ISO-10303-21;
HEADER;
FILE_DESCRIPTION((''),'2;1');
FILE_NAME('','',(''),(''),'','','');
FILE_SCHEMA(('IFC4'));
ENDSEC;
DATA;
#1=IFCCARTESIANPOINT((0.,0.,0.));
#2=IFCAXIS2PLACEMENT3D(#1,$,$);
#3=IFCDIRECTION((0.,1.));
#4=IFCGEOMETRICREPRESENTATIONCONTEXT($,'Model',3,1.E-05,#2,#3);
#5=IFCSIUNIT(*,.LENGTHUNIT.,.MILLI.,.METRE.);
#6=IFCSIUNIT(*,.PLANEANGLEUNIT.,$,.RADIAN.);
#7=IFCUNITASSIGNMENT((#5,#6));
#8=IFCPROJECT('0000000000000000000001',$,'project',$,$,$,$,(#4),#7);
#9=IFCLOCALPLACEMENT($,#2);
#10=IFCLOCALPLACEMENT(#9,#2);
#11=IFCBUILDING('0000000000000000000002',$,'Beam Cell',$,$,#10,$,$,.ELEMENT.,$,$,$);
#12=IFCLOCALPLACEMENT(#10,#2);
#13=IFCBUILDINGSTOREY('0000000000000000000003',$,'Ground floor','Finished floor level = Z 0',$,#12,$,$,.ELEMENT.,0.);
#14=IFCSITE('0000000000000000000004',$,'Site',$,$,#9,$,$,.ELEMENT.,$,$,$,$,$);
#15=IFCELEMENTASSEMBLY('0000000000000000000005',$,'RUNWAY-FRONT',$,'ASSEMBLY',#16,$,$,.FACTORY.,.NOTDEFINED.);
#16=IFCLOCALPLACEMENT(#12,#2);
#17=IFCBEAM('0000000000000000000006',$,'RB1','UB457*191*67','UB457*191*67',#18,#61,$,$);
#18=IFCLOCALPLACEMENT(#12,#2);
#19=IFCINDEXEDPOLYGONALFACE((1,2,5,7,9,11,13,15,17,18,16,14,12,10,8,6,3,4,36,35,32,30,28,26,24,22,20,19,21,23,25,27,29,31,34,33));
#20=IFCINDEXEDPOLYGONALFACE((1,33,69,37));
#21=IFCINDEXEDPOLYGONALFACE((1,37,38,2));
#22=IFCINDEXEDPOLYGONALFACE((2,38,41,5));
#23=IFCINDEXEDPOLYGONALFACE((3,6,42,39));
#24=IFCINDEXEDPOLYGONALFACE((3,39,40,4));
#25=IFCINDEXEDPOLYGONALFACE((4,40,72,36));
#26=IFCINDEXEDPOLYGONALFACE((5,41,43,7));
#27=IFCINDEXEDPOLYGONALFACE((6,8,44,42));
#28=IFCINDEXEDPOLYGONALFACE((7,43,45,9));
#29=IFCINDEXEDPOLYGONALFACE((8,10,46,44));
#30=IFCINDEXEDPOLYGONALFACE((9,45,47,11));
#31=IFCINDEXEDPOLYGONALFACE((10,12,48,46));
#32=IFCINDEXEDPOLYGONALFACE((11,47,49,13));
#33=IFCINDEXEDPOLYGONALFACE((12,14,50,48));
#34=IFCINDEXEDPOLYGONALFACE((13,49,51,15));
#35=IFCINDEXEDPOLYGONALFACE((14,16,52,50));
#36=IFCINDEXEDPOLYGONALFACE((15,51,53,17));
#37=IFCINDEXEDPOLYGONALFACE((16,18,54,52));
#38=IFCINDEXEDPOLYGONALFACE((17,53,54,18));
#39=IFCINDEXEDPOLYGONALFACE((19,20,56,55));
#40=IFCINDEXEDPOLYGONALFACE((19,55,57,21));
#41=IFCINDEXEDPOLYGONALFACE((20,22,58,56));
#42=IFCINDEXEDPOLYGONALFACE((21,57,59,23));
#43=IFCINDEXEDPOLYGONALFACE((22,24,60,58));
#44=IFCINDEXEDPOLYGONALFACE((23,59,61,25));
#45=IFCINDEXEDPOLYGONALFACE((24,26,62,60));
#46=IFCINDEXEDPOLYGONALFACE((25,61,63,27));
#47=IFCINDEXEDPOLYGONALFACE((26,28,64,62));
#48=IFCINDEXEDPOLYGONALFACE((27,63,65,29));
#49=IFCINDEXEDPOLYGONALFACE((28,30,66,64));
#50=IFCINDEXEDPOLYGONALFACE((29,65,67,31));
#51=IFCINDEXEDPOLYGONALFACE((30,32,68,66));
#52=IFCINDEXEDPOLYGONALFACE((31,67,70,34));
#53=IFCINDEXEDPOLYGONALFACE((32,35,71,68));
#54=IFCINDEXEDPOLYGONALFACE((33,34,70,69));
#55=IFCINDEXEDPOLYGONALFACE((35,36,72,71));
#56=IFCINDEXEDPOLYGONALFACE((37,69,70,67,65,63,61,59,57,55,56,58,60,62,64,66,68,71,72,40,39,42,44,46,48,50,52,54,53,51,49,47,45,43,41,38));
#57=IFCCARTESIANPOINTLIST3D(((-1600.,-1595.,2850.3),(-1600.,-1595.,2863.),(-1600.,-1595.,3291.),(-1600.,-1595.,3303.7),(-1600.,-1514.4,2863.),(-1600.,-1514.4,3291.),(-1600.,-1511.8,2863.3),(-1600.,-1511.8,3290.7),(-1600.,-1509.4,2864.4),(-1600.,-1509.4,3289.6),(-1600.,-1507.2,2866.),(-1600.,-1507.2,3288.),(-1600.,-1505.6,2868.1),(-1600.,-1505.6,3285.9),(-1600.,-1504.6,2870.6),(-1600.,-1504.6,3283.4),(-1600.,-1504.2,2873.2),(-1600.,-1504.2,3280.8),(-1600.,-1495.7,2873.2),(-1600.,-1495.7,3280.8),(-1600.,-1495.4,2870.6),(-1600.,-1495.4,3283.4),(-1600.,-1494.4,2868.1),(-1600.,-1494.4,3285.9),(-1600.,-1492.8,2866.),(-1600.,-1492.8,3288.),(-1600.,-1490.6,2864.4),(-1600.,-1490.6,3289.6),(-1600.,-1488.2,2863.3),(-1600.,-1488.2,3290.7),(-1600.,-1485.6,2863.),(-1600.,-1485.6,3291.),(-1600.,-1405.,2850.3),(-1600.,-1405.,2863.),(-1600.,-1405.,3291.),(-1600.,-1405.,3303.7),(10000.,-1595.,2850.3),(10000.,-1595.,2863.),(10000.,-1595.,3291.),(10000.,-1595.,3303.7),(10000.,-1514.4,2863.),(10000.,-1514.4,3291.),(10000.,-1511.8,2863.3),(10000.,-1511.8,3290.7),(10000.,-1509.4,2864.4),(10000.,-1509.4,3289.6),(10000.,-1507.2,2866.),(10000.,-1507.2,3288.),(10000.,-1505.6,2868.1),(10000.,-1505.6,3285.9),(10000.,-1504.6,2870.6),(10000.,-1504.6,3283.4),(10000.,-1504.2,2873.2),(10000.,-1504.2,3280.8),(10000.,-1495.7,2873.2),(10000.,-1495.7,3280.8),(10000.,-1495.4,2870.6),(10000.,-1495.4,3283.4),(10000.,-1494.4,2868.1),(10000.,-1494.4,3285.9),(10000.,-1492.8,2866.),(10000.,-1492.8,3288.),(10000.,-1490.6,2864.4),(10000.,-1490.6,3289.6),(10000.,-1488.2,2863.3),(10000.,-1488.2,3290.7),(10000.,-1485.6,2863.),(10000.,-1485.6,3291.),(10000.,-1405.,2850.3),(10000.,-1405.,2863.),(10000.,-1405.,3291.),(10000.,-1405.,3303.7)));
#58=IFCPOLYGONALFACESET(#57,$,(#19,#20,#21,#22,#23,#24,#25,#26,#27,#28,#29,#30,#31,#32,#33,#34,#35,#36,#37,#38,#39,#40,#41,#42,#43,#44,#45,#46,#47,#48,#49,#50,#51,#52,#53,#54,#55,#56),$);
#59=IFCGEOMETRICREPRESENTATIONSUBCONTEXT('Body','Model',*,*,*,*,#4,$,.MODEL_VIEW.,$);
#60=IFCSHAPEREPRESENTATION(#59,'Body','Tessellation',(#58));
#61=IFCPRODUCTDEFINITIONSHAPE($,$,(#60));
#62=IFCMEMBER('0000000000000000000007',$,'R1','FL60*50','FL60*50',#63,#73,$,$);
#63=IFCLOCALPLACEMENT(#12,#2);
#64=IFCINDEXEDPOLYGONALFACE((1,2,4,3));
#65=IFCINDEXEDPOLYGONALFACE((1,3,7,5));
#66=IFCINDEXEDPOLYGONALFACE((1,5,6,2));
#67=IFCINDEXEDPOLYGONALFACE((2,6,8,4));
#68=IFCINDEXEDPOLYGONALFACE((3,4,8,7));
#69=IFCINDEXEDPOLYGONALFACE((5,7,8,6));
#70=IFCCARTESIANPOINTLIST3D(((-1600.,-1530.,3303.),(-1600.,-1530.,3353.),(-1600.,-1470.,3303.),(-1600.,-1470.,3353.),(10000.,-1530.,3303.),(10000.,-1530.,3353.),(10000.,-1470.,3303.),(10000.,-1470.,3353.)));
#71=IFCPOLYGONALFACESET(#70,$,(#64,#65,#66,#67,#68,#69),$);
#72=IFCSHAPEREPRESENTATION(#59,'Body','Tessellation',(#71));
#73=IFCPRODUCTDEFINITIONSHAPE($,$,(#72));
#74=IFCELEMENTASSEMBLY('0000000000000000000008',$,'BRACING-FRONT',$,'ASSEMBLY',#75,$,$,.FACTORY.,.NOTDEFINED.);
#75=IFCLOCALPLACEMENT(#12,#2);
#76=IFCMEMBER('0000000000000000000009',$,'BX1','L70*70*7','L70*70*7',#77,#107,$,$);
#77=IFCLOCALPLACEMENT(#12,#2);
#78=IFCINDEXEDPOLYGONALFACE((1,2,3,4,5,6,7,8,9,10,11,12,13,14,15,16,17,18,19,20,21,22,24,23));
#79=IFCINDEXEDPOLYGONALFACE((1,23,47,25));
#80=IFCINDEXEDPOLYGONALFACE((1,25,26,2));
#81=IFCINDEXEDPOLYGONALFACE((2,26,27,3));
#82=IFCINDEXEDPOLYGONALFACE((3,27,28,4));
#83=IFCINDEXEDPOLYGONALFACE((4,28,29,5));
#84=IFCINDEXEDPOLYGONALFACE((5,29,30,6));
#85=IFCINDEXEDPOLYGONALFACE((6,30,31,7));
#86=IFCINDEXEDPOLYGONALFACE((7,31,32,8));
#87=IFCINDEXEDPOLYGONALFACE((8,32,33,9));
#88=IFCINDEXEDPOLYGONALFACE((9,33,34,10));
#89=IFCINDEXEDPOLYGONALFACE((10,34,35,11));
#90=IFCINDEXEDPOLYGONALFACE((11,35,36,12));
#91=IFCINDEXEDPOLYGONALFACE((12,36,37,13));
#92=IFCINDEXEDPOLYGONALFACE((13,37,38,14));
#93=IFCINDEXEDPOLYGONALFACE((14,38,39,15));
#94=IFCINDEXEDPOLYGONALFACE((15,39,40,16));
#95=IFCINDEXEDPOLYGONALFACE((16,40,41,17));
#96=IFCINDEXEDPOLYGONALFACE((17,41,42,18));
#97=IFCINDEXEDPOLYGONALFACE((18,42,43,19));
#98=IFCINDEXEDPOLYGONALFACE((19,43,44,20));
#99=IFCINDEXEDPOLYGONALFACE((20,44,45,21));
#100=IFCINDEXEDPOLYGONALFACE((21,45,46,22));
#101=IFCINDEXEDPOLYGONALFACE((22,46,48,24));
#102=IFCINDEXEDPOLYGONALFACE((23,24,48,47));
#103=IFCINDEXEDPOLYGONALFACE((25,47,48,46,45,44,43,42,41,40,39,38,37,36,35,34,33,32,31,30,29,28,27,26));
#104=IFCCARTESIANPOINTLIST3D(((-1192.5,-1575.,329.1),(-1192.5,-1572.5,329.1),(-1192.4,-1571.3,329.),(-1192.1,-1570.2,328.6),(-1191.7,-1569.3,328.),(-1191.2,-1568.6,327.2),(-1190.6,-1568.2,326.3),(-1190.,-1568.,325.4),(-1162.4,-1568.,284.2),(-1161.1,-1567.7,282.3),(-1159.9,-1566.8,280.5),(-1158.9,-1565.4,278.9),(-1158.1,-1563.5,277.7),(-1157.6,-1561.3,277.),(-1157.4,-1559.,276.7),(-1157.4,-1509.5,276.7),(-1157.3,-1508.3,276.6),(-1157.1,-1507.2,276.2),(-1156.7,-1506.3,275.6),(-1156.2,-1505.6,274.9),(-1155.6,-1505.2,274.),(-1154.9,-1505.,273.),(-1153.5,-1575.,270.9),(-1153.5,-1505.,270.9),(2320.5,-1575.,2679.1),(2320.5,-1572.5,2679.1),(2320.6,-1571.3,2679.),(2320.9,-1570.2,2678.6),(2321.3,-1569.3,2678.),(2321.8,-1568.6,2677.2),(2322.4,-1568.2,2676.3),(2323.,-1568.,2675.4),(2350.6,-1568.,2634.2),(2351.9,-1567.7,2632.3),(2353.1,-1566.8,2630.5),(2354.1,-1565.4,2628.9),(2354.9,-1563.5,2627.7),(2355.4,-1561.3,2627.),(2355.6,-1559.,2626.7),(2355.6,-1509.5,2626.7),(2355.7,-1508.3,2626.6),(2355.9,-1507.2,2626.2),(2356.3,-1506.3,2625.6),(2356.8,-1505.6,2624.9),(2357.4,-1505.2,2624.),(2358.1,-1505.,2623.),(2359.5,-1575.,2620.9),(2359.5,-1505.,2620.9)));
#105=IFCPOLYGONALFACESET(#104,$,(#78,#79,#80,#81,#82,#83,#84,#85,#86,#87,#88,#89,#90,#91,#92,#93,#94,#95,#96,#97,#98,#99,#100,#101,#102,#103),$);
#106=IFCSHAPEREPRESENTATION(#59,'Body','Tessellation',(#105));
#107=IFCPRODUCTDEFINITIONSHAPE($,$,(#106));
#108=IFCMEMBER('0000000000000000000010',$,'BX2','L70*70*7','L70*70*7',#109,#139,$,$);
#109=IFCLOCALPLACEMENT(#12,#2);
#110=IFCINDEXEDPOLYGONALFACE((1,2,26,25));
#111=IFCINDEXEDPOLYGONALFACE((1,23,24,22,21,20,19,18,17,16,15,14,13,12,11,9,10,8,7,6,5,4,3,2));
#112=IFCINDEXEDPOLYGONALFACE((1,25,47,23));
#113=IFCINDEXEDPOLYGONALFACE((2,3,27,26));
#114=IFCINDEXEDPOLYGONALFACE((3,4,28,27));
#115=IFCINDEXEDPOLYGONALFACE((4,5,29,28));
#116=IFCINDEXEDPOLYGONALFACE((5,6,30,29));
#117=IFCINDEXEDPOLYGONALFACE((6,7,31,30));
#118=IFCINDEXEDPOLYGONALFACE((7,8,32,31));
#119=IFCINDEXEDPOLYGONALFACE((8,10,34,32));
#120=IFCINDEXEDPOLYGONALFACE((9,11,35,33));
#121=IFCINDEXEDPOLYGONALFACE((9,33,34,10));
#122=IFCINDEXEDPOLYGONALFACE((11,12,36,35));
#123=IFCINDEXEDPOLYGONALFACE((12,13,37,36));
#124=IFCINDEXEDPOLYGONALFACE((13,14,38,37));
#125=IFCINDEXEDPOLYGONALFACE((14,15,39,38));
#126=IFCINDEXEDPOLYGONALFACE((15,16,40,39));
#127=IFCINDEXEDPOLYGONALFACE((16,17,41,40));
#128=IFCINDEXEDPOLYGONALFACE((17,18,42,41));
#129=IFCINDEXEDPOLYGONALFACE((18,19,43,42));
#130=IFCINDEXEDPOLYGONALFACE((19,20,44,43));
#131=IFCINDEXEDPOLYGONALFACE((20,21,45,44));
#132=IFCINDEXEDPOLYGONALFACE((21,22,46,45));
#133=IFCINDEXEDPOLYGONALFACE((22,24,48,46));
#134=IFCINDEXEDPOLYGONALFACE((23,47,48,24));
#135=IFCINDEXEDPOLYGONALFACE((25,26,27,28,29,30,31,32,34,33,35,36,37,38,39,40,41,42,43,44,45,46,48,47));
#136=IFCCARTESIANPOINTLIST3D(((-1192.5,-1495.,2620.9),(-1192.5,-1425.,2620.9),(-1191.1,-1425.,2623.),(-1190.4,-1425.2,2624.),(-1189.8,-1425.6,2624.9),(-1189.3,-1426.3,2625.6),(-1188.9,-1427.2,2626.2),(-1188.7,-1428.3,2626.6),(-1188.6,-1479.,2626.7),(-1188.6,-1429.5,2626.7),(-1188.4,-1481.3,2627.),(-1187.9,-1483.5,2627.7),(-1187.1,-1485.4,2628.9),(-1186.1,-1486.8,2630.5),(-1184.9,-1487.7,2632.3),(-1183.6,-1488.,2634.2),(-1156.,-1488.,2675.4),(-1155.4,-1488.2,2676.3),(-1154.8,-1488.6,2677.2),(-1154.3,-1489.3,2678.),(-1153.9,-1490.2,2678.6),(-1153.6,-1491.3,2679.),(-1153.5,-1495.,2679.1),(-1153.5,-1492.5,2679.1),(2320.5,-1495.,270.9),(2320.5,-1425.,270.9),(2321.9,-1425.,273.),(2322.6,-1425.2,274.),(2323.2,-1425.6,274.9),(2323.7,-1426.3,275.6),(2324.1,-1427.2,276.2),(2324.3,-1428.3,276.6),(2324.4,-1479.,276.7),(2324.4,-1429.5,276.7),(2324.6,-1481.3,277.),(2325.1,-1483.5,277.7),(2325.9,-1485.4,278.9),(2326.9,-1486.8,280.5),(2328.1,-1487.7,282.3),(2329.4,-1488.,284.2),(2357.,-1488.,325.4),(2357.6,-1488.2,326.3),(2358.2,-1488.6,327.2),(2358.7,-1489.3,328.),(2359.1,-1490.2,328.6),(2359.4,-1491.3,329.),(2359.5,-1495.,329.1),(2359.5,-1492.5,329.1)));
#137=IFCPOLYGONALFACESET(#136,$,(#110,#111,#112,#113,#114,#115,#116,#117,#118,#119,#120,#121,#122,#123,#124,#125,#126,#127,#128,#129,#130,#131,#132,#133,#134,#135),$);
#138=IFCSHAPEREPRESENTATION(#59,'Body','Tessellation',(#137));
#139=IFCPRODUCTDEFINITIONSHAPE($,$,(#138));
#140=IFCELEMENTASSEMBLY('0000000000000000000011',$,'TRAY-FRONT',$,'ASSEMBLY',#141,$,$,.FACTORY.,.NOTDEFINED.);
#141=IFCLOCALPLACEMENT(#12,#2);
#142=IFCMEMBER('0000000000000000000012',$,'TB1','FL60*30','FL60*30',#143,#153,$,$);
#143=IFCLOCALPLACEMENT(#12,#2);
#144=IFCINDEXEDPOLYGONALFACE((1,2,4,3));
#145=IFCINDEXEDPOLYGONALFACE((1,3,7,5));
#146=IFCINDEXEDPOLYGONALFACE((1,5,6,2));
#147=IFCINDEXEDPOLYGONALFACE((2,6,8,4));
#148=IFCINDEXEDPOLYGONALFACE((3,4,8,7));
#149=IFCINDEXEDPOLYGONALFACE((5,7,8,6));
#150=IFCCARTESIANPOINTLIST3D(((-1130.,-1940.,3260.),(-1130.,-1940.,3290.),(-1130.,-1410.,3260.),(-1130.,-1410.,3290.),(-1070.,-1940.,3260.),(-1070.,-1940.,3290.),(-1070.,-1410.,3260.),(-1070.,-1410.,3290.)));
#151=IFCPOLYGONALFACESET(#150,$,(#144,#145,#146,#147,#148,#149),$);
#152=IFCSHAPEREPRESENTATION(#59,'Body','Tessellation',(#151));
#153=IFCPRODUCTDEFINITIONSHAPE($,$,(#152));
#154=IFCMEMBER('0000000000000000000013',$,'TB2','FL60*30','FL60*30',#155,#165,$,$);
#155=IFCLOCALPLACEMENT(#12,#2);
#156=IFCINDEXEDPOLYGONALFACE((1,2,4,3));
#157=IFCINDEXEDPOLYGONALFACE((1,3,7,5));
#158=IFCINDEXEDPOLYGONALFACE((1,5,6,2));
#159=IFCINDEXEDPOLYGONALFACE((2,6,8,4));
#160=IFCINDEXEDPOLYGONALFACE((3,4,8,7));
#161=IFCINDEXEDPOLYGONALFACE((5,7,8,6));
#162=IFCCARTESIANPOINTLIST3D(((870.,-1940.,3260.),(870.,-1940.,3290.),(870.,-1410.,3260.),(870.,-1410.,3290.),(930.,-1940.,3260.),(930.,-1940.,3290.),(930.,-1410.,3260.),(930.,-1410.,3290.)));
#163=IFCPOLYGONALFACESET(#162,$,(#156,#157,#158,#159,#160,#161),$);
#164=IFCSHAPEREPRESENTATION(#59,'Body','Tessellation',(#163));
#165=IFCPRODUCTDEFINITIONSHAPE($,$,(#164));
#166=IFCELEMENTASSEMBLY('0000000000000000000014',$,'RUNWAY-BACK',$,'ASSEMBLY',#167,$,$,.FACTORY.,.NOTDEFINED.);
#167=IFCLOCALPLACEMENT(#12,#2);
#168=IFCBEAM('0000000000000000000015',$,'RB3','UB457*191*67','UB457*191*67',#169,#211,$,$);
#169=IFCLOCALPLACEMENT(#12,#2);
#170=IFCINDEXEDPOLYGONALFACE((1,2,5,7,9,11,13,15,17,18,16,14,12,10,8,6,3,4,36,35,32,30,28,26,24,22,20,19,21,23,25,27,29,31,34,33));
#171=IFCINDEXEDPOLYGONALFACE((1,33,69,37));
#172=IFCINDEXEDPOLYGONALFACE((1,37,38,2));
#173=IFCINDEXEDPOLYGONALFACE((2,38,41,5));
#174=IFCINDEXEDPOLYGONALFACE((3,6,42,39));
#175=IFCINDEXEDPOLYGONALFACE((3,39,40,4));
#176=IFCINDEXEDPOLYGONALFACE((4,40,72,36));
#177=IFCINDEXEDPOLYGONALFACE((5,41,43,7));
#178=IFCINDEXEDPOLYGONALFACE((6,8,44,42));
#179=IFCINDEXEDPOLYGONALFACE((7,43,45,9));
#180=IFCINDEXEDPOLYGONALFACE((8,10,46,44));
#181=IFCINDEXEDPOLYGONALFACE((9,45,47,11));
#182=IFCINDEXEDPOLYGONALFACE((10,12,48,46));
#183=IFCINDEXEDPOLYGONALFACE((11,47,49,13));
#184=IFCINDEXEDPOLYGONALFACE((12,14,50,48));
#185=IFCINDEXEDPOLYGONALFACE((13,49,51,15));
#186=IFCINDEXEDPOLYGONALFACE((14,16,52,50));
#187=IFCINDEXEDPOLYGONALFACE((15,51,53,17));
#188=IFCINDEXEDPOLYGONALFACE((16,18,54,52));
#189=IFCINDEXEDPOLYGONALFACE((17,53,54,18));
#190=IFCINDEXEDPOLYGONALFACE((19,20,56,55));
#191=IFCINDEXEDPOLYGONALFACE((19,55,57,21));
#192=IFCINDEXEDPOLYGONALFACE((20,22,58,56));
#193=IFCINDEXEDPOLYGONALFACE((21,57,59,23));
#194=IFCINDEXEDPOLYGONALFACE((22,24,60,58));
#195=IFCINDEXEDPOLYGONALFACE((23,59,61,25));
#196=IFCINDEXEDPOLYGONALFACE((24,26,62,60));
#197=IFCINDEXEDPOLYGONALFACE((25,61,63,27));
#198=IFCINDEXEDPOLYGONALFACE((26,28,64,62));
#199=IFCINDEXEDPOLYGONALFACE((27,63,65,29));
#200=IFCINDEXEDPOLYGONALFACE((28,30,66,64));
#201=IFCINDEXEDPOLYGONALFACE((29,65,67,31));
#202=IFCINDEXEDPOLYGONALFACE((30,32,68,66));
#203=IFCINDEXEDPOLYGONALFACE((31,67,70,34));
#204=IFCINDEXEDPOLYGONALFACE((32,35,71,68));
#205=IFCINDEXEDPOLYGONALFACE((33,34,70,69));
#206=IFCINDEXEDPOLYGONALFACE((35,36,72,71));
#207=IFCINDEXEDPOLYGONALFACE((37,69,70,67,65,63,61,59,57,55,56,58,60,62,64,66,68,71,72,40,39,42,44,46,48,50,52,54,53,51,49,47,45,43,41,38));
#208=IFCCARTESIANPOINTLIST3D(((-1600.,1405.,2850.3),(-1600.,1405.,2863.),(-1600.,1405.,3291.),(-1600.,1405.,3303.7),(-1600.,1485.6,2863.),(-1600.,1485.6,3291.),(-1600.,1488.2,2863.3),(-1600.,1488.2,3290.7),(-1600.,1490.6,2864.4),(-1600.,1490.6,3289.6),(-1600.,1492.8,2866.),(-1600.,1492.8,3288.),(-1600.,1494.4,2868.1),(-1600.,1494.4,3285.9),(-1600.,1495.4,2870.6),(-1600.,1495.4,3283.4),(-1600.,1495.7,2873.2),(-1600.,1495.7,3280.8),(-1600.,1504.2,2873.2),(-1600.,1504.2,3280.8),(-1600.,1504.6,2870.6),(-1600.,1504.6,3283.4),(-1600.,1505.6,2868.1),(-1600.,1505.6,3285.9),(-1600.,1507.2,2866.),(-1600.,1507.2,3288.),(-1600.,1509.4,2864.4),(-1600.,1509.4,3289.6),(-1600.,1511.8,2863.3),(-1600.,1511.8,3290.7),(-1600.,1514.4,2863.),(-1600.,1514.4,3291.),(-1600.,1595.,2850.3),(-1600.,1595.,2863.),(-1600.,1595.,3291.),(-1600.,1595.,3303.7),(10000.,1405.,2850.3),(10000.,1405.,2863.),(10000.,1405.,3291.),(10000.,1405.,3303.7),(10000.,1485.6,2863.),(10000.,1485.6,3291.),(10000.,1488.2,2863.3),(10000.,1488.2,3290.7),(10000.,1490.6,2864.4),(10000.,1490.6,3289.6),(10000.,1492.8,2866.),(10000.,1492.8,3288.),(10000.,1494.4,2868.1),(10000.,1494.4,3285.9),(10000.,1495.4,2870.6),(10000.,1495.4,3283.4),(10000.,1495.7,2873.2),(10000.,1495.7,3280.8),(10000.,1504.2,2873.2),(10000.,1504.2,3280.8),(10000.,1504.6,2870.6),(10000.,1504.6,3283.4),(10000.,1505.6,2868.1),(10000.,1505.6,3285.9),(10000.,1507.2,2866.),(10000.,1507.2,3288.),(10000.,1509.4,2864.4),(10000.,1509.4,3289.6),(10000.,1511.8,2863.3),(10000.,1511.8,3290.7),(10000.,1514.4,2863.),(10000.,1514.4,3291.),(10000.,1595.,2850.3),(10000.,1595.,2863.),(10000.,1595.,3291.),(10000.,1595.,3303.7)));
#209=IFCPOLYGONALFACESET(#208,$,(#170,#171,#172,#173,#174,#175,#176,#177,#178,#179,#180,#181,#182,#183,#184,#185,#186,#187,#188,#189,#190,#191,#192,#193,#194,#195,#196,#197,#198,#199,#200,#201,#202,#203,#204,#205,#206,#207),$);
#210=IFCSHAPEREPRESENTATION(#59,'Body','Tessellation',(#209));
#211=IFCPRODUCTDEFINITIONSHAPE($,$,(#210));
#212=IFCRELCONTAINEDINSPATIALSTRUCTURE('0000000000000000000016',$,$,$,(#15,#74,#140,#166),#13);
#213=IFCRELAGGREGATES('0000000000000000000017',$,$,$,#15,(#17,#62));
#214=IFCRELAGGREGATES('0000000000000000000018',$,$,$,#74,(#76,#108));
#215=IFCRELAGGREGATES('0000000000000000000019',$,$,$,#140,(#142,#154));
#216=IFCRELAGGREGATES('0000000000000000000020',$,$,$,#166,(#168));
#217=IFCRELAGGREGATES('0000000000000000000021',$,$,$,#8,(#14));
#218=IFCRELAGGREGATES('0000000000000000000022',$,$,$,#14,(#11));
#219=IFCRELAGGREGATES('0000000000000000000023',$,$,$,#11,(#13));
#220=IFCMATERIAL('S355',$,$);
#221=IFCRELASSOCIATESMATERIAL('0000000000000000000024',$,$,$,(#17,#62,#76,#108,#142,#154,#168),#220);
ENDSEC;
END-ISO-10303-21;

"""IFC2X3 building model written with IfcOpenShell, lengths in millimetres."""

from ifc_helpers import new_model, si_unit, direction, frame, origin, origin_2d, place, context, subcontext, project, spatial, rectangle, i_section, l_section, extrude, material, element, aggregate, save


model = new_model("IFC2X3")

# Units and contexts
model_context = context("Model", 3, precision=1e-05, world=origin(), true_north=direction((0.0, 1.0)))
body_context = subcontext(model_context, "Body", "Model", "MODEL_VIEW")
ifc_project = project(units=[si_unit("LENGTHUNIT", "METRE", prefix="MILLI"), si_unit("PLANEANGLEUNIT", "RADIAN")], contexts=[model_context])

# Site, building, storey
site_placement = place(None, origin())
site = spatial("IfcSite", under=ifc_project, at=site_placement, Name="Site", CompositionType="ELEMENT")
building_placement = place(site_placement, origin())
building = spatial("IfcBuilding", under=site, at=building_placement, Name="Beam Cell", CompositionType="ELEMENT")
storey_placement = place(building_placement, origin())
storey = spatial("IfcBuildingStorey", under=building, at=storey_placement, Name="Ground floor", Description="Finished floor level = Z 0", CompositionType="ELEMENT", Elevation=0.0)

# Shared definitions
ifc_material = material(Name="S355")

# Element assembly, beam, member
assembly_1_placement = place(storey_placement, origin())
assembly_1 = element("IfcElementAssembly", 1, at=assembly_1_placement, inside=storey, Name="RUNWAY-FRONT", ObjectType="ASSEMBLY", AssemblyPlace="FACTORY", PredefinedType="NOTDEFINED")
beam_1_placement = place(storey_placement, frame((-1600.0, -1500.0, 3077.0), z_axis=(1.0, 0.0, 0.0), x_axis=(0.0, 1.0, 0.0)))
beam_1 = element("IfcBeam", 2, at=beam_1_placement, material=ifc_material, Name="RB1", Description="UB457*191*67", ObjectType="UB457*191*67", context=body_context, shape_type="SweptSolid", body=[
    extrude(i_section(OverallWidth=189.9, OverallDepth=453.4, WebThickness=8.5, FlangeThickness=12.7, FilletRadius=10.2, at=origin_2d()), origin(), (0.0, 0.0, 1.0), 11600.0),
])
member_1_placement = place(storey_placement, frame((-1600.0, -1500.0, 3328.0), z_axis=(1.0, 0.0, 0.0), x_axis=(0.0, 1.0, 0.0)))
member_1 = element("IfcMember", 3, at=member_1_placement, material=ifc_material, Name="R1", Description="FL60*50", ObjectType="FL60*50", context=body_context, shape_type="SweptSolid", body=[
    extrude(rectangle(XDim=60.0, YDim=50.0, at=origin_2d()), origin(), (0.0, 0.0, 1.0), 11600.0),
])
aggregate(assembly_1, [beam_1, member_1])

# Element assemblies, members
assembly_2_placement = place(storey_placement, origin())
assembly_2 = element("IfcElementAssembly", 4, at=assembly_2_placement, inside=storey, Name="BRACING-FRONT", ObjectType="ASSEMBLY", AssemblyPlace="FACTORY", PredefinedType="NOTDEFINED")
member_2_placement = place(storey_placement, frame((-1173.0, -1540.0, 300.0), z_axis=(0.831176, 0.0, 0.55601), x_axis=(0.0, 1.0, 0.0)))
member_2 = element("IfcMember", 5, at=member_2_placement, material=ifc_material, Name="BX1", Description="L70*70*7", ObjectType="L70*70*7", context=body_context, shape_type="SweptSolid", body=[
    extrude(l_section(Depth=70.0, Width=70.0, Thickness=7.0, FilletRadius=9.0, EdgeRadius=4.5, at=origin_2d()), origin(), (0.0, 0.0, 1.0), 4226.5),
])
member_3_placement = place(storey_placement, frame((-1173.0, -1460.0, 2650.0), z_axis=(0.831176, 0.0, -0.55601), x_axis=(0.0, 1.0, 0.0)))
member_3 = element("IfcMember", 6, at=member_3_placement, material=ifc_material, Name="BX2", Description="L70*70*7", ObjectType="L70*70*7", context=body_context, shape_type="SweptSolid", body=[
    extrude(l_section(Depth=70.0, Width=70.0, Thickness=7.0, FilletRadius=9.0, EdgeRadius=4.5, at=origin_2d()), origin(), (0.0, 0.0, 1.0), 4226.5),
])
aggregate(assembly_2, [member_2, member_3])
assembly_3_placement = place(storey_placement, origin())
assembly_3 = element("IfcElementAssembly", 7, at=assembly_3_placement, inside=storey, Name="TRAY-FRONT", ObjectType="ASSEMBLY", AssemblyPlace="FACTORY", PredefinedType="NOTDEFINED")
member_4_placement = place(storey_placement, frame((-1100.0, -1940.0, 3275.0), z_axis=(0.0, 1.0, 0.0), x_axis=(1.0, 0.0, 0.0)))
member_4 = element("IfcMember", 8, at=member_4_placement, material=ifc_material, Name="TB1", Description="FL60*30", ObjectType="FL60*30", context=body_context, shape_type="SweptSolid", body=[
    extrude(rectangle(XDim=60.0, YDim=30.0, at=origin_2d()), origin(), (0.0, 0.0, 1.0), 530.0),
])
member_5_placement = place(storey_placement, frame((900.0, -1940.0, 3275.0), z_axis=(0.0, 1.0, 0.0), x_axis=(1.0, 0.0, 0.0)))
member_5 = element("IfcMember", 9, at=member_5_placement, material=ifc_material, Name="TB2", Description="FL60*30", ObjectType="FL60*30", context=body_context, shape_type="SweptSolid", body=[
    extrude(rectangle(XDim=60.0, YDim=30.0, at=origin_2d()), origin(), (0.0, 0.0, 1.0), 530.0),
])
aggregate(assembly_3, [member_4, member_5])

# Element assembly, beam
assembly_4_placement = place(storey_placement, origin())
assembly_4 = element("IfcElementAssembly", 10, at=assembly_4_placement, inside=storey, Name="RUNWAY-BACK", ObjectType="ASSEMBLY", AssemblyPlace="FACTORY", PredefinedType="NOTDEFINED")
beam_2_placement = place(storey_placement, frame((-1600.0, 1500.0, 3077.0), z_axis=(1.0, 0.0, 0.0), x_axis=(0.0, 1.0, 0.0)))
beam_2 = element("IfcBeam", 11, at=beam_2_placement, material=ifc_material, Name="RB3", Description="UB457*191*67", ObjectType="UB457*191*67", context=body_context, shape_type="SweptSolid", body=[
    extrude(i_section(OverallWidth=189.9, OverallDepth=453.4, WebThickness=8.5, FlangeThickness=12.7, FilletRadius=10.2, at=origin_2d()), origin(), (0.0, 0.0, 1.0), 11600.0),
])
aggregate(assembly_4, [beam_2])

save(model, "model.ifc")
